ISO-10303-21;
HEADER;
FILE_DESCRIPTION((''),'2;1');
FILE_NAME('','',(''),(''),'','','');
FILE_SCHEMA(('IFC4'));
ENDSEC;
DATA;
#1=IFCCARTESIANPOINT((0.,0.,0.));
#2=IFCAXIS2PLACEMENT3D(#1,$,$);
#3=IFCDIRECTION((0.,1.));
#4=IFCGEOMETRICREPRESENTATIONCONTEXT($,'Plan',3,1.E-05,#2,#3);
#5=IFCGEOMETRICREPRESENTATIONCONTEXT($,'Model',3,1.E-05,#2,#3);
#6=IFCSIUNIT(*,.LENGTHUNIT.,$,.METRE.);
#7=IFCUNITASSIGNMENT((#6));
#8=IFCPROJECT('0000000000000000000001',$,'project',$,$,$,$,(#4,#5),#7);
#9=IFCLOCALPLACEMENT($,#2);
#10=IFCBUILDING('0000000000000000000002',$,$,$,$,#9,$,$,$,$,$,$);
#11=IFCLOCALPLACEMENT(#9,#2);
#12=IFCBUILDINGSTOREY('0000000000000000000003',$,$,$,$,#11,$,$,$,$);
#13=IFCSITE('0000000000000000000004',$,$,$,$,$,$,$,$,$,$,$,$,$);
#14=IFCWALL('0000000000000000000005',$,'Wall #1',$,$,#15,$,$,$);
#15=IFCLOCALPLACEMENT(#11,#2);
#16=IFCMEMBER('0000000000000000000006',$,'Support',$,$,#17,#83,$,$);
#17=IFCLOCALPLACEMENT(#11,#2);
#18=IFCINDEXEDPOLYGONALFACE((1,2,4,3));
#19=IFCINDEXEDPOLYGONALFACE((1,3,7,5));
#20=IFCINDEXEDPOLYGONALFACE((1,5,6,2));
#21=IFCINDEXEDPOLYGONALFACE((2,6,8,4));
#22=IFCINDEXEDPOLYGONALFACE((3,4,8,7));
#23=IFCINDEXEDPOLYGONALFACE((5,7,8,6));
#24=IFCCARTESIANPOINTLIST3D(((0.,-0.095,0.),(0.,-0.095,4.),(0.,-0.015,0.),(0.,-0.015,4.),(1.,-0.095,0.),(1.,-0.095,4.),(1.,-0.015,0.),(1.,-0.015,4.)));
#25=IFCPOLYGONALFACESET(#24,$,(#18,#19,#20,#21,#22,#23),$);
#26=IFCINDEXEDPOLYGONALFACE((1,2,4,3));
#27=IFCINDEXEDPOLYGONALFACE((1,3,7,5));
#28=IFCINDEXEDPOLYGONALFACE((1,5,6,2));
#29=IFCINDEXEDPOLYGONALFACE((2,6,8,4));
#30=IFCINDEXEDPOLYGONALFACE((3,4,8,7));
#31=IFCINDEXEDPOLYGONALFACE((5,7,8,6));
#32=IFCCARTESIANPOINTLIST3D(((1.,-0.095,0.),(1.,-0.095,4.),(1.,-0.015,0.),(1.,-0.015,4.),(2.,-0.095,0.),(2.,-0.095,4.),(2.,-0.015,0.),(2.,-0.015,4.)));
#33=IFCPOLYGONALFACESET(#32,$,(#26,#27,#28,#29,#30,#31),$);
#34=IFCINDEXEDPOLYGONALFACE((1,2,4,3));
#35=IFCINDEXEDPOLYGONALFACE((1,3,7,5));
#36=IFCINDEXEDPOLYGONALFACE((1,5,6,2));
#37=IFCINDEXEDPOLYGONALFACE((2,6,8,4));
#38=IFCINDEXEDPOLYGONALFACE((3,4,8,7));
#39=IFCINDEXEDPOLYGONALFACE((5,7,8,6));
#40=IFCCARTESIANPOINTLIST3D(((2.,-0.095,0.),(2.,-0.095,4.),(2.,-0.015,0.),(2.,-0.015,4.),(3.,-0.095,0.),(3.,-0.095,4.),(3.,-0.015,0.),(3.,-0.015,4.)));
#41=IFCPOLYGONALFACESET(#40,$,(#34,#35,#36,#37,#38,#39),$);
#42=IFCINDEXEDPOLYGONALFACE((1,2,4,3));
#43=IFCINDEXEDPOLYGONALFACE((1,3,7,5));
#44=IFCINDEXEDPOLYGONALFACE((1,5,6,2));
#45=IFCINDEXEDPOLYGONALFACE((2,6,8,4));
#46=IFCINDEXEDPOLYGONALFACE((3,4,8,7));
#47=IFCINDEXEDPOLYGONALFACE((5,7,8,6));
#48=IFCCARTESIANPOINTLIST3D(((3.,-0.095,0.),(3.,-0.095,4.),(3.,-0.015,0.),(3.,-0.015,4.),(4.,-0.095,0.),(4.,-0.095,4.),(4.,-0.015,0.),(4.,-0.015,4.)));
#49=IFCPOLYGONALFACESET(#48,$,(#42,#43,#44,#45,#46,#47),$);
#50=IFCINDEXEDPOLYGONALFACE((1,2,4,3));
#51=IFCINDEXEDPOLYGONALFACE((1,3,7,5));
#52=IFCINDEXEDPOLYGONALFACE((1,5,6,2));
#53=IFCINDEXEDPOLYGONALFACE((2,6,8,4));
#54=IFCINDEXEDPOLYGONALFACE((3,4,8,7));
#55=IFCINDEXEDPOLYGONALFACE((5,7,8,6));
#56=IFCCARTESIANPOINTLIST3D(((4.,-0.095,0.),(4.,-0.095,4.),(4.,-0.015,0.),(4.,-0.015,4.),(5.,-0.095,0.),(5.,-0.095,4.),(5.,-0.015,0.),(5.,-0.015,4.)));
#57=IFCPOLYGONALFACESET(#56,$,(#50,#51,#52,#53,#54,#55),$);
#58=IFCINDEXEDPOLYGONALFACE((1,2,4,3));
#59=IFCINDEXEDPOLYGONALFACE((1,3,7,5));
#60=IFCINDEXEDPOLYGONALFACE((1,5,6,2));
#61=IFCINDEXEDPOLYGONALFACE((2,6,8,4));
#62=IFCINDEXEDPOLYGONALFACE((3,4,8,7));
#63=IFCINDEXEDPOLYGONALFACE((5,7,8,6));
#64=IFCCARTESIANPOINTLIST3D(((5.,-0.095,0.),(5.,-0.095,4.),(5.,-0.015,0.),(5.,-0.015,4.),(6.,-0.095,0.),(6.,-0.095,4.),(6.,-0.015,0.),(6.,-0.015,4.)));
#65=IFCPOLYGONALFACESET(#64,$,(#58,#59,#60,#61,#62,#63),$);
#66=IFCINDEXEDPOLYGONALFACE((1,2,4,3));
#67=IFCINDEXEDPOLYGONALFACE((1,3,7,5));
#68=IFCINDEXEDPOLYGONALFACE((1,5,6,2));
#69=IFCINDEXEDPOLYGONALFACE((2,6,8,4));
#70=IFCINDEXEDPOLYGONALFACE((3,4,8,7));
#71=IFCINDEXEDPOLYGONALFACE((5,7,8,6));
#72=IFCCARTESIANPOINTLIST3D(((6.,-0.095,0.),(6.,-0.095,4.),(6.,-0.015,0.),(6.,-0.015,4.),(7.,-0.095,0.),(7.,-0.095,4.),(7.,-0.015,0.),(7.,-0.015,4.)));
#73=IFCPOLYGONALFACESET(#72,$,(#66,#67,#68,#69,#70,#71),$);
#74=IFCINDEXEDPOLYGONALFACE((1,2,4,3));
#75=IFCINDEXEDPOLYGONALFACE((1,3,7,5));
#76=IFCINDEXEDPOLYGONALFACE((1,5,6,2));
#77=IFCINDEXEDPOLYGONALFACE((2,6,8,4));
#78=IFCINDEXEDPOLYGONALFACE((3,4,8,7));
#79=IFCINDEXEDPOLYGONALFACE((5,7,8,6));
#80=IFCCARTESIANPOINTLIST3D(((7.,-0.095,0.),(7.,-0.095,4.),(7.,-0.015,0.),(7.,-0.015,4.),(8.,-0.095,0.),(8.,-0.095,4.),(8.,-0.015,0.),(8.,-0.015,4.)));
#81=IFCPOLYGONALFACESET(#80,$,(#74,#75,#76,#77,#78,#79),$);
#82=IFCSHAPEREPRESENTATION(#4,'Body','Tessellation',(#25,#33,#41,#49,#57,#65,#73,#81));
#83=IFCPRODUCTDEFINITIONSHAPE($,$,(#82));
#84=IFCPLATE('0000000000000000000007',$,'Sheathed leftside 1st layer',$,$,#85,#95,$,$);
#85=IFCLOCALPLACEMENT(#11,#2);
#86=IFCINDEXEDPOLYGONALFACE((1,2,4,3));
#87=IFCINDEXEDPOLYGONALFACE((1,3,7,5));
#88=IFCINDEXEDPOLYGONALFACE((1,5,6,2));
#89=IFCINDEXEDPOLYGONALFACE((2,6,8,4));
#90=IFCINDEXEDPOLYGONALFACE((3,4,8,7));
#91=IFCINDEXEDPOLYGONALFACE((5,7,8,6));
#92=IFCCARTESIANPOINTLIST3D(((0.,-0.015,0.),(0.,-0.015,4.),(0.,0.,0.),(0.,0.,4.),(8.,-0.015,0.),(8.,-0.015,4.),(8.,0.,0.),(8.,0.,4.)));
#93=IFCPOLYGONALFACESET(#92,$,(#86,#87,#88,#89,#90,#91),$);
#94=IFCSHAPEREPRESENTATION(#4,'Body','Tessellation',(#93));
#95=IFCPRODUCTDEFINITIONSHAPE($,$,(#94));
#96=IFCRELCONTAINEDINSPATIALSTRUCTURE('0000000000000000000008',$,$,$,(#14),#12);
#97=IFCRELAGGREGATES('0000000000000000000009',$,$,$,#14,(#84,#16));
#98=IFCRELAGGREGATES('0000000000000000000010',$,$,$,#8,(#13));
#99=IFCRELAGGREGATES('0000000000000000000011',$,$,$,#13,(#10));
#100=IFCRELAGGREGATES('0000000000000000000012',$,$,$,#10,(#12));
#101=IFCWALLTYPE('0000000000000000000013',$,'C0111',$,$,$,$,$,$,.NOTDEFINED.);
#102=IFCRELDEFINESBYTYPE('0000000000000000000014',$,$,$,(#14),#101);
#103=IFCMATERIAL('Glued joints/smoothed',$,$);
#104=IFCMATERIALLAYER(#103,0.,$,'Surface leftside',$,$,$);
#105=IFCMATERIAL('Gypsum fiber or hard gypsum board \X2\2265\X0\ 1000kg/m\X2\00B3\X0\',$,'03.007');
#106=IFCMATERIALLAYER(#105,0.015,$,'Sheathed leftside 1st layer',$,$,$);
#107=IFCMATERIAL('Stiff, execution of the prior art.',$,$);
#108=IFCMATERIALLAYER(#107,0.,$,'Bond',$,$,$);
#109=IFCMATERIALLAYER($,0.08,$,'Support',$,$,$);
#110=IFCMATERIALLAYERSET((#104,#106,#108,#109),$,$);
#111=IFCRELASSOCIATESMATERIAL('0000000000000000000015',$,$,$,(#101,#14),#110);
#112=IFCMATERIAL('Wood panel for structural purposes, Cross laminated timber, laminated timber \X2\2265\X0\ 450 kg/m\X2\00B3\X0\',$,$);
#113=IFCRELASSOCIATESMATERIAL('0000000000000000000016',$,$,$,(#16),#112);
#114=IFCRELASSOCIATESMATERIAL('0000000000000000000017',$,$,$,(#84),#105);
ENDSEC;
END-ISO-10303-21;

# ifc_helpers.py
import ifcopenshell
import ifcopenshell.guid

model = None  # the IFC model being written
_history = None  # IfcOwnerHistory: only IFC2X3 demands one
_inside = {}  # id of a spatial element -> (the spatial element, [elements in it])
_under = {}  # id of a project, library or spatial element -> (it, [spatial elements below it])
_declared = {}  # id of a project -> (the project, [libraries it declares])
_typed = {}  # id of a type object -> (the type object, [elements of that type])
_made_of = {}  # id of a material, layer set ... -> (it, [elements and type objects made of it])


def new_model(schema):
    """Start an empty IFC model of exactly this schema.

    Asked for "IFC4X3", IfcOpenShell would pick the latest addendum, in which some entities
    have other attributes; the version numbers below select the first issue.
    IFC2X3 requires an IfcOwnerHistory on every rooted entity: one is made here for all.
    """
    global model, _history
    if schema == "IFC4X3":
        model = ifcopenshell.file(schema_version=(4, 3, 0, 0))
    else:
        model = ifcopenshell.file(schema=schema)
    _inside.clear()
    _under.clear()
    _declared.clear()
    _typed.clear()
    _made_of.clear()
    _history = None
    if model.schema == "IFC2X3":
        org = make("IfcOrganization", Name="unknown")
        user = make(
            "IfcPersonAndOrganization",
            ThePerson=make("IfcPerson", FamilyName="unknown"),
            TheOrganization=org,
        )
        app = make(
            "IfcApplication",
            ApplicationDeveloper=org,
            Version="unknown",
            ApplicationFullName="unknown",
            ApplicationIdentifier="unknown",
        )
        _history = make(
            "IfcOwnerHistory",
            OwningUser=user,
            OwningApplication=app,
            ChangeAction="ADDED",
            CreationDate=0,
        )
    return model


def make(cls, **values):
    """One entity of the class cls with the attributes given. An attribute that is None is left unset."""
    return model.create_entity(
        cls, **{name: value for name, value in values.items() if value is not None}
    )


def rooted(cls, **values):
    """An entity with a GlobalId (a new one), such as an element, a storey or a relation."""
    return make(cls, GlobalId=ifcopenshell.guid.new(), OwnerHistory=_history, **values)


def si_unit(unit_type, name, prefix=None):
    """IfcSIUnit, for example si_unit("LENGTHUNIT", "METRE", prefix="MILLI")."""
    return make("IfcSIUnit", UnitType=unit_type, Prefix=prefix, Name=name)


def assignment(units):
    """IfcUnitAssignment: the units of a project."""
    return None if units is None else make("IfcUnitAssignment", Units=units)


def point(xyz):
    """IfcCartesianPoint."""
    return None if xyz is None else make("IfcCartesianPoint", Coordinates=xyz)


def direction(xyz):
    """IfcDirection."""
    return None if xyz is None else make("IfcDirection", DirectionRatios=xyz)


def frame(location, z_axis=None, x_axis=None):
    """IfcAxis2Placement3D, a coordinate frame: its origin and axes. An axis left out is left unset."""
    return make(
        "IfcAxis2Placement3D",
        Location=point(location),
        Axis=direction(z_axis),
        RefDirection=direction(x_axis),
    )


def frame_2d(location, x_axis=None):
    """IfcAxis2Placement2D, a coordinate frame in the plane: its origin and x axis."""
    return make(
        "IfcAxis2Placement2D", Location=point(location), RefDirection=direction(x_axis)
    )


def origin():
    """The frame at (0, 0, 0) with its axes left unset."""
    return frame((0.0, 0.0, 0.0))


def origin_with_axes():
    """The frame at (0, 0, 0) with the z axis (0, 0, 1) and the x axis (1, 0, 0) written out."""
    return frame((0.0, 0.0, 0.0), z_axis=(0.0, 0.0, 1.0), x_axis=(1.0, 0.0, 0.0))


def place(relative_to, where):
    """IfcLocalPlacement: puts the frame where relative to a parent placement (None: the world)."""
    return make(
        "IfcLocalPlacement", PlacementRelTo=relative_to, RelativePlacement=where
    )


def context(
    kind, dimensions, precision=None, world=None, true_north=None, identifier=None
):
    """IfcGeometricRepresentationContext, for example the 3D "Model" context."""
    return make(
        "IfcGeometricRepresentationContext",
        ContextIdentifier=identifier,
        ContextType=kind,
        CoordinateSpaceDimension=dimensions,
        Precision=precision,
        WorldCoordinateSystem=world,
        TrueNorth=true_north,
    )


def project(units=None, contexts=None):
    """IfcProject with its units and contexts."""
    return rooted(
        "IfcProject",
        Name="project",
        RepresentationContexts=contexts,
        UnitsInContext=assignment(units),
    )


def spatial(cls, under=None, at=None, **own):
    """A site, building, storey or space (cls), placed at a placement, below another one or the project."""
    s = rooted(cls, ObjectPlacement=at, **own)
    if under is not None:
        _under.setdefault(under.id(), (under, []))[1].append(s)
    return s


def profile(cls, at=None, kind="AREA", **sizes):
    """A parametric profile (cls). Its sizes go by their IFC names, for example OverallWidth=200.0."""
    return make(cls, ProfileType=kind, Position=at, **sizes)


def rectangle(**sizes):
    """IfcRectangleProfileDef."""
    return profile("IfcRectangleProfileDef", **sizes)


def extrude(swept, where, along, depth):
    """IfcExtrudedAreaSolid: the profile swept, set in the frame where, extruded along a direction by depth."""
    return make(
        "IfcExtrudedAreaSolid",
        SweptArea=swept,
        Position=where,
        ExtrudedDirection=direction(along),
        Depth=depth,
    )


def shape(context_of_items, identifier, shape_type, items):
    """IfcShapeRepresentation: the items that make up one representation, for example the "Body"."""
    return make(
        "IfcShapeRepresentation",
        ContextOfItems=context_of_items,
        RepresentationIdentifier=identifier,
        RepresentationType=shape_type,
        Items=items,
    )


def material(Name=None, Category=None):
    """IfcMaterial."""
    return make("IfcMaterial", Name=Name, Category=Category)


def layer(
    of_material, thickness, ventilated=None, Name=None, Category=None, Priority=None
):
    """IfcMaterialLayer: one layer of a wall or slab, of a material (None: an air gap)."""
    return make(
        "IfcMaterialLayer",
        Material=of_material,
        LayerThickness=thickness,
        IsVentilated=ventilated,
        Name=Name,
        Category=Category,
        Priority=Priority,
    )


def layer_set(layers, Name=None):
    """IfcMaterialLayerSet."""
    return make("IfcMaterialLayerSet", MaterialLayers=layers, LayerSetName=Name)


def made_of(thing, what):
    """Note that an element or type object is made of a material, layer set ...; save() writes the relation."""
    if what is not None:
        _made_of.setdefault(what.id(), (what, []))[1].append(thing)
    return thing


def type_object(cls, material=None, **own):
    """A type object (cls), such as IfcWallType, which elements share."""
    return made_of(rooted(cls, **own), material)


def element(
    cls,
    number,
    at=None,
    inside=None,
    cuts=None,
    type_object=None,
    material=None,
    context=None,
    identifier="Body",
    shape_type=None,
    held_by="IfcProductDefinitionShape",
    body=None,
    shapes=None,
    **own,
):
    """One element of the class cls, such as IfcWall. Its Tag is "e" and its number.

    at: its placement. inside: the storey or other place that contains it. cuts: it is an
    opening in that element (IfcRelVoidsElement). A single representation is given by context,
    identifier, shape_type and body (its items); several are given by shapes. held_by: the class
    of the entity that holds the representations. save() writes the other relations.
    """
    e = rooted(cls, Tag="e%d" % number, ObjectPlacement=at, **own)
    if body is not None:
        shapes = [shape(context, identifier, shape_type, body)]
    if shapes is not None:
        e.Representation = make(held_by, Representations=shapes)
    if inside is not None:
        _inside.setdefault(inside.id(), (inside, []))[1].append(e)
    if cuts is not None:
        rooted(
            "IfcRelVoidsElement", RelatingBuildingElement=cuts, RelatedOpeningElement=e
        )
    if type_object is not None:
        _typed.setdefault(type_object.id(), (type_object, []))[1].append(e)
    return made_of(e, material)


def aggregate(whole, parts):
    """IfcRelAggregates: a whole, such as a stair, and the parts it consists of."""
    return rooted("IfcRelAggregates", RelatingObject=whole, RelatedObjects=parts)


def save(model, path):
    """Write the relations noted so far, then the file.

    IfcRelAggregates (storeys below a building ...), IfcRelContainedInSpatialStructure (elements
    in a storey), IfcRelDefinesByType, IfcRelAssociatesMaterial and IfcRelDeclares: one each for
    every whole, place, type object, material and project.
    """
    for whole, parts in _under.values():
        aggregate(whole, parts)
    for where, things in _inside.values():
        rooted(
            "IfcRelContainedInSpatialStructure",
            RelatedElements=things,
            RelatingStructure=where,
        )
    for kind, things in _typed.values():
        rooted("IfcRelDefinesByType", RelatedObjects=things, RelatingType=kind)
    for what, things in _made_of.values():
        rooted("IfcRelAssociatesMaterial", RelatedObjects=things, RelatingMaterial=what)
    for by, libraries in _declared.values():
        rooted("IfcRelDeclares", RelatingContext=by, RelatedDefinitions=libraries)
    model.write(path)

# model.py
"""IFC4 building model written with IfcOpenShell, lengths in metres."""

from ifc_helpers import new_model, si_unit, direction, frame, frame_2d, origin, origin_with_axes, place, context, project, spatial, rectangle, extrude, material, layer, layer_set, type_object, element, aggregate, save


model = new_model("IFC4")

# Units and contexts
plan_context = context("Plan", 3, precision=1e-05, world=origin(), true_north=direction((0.0, 1.0)))
model_context = context("Model", 3, precision=1e-05, world=origin(), true_north=direction((0.0, 1.0)))
ifc_project = project(units=[si_unit("LENGTHUNIT", "METRE")], contexts=[plan_context, model_context])

# Site, building, storey
site = spatial("IfcSite", under=ifc_project)
building_placement = place(None, origin())
building = spatial("IfcBuilding", under=site, at=building_placement)
storey_placement = place(building_placement, origin())
storey = spatial("IfcBuildingStorey", under=building, at=storey_placement)

# Wall, member, plate
ifc_material_1 = material(Name="Glued joints/smoothed")
ifc_layer_1 = layer(ifc_material_1, 0.0, Name="Surface leftside")
ifc_material_2 = material(Name="Gypsum fiber or hard gypsum board ≥ 1000kg/m³", Category="03.007")
ifc_layer_2 = layer(ifc_material_2, 0.015, Name="Sheathed leftside 1st layer")
ifc_material_3 = material(Name="Stiff, execution of the prior art.")
ifc_layer_3 = layer(ifc_material_3, 0.0, Name="Bond")
ifc_layer_4 = layer(None, 0.08, Name="Support")
ifc_layer_set = layer_set([ifc_layer_1, ifc_layer_2, ifc_layer_3, ifc_layer_4])
wall_type = type_object("IfcWallType", Name="C0111", PredefinedType="NOTDEFINED", material=ifc_layer_set)
wall_placement = place(None, frame((0.0, 0.0, 0.0), z_axis=(0.0, -1.0, 0.0), x_axis=(1.0, 0.0, 0.0)))
wall = element("IfcWall", 1, at=wall_placement, inside=storey, type_object=wall_type, material=ifc_layer_set, Name="Wall #1")
ifc_material_4 = material(Name="Wood panel for structural purposes, Cross laminated timber, laminated timber ≥ 450 kg/m³")
member_placement = place(wall_placement, origin())
member = element("IfcMember", 2, at=member_placement, material=ifc_material_4, Name="Support", context=plan_context, shape_type="SweptSolid", body=[
    extrude(rectangle(XDim=1.0, YDim=0.08, at=frame_2d((0.5, 0.04), x_axis=(1.0, 0.0))), frame((0.0, 4.0, 0.015), z_axis=(0.0, -1.0, 0.0), x_axis=(1.0, 0.0, 0.0)), (0.0, 0.0, 1.0), 4.0),
    extrude(rectangle(XDim=1.0, YDim=0.08, at=frame_2d((0.5, 0.04), x_axis=(1.0, 0.0))), frame((1.0, 4.0, 0.015), z_axis=(0.0, -1.0, 0.0), x_axis=(1.0, 0.0, 0.0)), (0.0, 0.0, 1.0), 4.0),
    extrude(rectangle(XDim=1.0, YDim=0.08, at=frame_2d((0.5, 0.04), x_axis=(1.0, 0.0))), frame((2.0, 4.0, 0.015), z_axis=(0.0, -1.0, 0.0), x_axis=(1.0, 0.0, 0.0)), (0.0, 0.0, 1.0), 4.0),
    extrude(rectangle(XDim=1.0, YDim=0.08, at=frame_2d((0.5, 0.04), x_axis=(1.0, 0.0))), frame((3.0, 4.0, 0.015), z_axis=(0.0, -1.0, 0.0), x_axis=(1.0, 0.0, 0.0)), (0.0, 0.0, 1.0), 4.0),
    extrude(rectangle(XDim=1.0, YDim=0.08, at=frame_2d((0.5, 0.04), x_axis=(1.0, 0.0))), frame((4.0, 4.0, 0.015), z_axis=(0.0, -1.0, 0.0), x_axis=(1.0, 0.0, 0.0)), (0.0, 0.0, 1.0), 4.0),
    extrude(rectangle(XDim=1.0, YDim=0.08, at=frame_2d((0.5, 0.04), x_axis=(1.0, 0.0))), frame((5.0, 4.0, 0.015), z_axis=(0.0, -1.0, 0.0), x_axis=(1.0, 0.0, 0.0)), (0.0, 0.0, 1.0), 4.0),
    extrude(rectangle(XDim=1.0, YDim=0.08, at=frame_2d((0.5, 0.04), x_axis=(1.0, 0.0))), frame((6.0, 4.0, 0.015), z_axis=(0.0, -1.0, 0.0), x_axis=(1.0, 0.0, 0.0)), (0.0, 0.0, 1.0), 4.0),
    extrude(rectangle(XDim=1.0, YDim=0.08, at=frame_2d((0.5, 0.04), x_axis=(1.0, 0.0))), frame((7.0, 4.0, 0.015), z_axis=(0.0, -1.0, 0.0), x_axis=(1.0, 0.0, 0.0)), (0.0, 0.0, 1.0), 4.0),
])
plate_placement = place(wall_placement, origin())
plate = element("IfcPlate", 3, at=plate_placement, material=ifc_material_2, Name="Sheathed leftside 1st layer", context=plan_context, shape_type="SweptSolid", body=[
    extrude(rectangle(XDim=8.0, YDim=4.0, at=frame_2d((4.0, 2.0), x_axis=(1.0, 0.0))), origin_with_axes(), (0.0, 0.0, 1.0), 0.015),
])
aggregate(wall, [plate, member])

save(model, "model.ifc")
